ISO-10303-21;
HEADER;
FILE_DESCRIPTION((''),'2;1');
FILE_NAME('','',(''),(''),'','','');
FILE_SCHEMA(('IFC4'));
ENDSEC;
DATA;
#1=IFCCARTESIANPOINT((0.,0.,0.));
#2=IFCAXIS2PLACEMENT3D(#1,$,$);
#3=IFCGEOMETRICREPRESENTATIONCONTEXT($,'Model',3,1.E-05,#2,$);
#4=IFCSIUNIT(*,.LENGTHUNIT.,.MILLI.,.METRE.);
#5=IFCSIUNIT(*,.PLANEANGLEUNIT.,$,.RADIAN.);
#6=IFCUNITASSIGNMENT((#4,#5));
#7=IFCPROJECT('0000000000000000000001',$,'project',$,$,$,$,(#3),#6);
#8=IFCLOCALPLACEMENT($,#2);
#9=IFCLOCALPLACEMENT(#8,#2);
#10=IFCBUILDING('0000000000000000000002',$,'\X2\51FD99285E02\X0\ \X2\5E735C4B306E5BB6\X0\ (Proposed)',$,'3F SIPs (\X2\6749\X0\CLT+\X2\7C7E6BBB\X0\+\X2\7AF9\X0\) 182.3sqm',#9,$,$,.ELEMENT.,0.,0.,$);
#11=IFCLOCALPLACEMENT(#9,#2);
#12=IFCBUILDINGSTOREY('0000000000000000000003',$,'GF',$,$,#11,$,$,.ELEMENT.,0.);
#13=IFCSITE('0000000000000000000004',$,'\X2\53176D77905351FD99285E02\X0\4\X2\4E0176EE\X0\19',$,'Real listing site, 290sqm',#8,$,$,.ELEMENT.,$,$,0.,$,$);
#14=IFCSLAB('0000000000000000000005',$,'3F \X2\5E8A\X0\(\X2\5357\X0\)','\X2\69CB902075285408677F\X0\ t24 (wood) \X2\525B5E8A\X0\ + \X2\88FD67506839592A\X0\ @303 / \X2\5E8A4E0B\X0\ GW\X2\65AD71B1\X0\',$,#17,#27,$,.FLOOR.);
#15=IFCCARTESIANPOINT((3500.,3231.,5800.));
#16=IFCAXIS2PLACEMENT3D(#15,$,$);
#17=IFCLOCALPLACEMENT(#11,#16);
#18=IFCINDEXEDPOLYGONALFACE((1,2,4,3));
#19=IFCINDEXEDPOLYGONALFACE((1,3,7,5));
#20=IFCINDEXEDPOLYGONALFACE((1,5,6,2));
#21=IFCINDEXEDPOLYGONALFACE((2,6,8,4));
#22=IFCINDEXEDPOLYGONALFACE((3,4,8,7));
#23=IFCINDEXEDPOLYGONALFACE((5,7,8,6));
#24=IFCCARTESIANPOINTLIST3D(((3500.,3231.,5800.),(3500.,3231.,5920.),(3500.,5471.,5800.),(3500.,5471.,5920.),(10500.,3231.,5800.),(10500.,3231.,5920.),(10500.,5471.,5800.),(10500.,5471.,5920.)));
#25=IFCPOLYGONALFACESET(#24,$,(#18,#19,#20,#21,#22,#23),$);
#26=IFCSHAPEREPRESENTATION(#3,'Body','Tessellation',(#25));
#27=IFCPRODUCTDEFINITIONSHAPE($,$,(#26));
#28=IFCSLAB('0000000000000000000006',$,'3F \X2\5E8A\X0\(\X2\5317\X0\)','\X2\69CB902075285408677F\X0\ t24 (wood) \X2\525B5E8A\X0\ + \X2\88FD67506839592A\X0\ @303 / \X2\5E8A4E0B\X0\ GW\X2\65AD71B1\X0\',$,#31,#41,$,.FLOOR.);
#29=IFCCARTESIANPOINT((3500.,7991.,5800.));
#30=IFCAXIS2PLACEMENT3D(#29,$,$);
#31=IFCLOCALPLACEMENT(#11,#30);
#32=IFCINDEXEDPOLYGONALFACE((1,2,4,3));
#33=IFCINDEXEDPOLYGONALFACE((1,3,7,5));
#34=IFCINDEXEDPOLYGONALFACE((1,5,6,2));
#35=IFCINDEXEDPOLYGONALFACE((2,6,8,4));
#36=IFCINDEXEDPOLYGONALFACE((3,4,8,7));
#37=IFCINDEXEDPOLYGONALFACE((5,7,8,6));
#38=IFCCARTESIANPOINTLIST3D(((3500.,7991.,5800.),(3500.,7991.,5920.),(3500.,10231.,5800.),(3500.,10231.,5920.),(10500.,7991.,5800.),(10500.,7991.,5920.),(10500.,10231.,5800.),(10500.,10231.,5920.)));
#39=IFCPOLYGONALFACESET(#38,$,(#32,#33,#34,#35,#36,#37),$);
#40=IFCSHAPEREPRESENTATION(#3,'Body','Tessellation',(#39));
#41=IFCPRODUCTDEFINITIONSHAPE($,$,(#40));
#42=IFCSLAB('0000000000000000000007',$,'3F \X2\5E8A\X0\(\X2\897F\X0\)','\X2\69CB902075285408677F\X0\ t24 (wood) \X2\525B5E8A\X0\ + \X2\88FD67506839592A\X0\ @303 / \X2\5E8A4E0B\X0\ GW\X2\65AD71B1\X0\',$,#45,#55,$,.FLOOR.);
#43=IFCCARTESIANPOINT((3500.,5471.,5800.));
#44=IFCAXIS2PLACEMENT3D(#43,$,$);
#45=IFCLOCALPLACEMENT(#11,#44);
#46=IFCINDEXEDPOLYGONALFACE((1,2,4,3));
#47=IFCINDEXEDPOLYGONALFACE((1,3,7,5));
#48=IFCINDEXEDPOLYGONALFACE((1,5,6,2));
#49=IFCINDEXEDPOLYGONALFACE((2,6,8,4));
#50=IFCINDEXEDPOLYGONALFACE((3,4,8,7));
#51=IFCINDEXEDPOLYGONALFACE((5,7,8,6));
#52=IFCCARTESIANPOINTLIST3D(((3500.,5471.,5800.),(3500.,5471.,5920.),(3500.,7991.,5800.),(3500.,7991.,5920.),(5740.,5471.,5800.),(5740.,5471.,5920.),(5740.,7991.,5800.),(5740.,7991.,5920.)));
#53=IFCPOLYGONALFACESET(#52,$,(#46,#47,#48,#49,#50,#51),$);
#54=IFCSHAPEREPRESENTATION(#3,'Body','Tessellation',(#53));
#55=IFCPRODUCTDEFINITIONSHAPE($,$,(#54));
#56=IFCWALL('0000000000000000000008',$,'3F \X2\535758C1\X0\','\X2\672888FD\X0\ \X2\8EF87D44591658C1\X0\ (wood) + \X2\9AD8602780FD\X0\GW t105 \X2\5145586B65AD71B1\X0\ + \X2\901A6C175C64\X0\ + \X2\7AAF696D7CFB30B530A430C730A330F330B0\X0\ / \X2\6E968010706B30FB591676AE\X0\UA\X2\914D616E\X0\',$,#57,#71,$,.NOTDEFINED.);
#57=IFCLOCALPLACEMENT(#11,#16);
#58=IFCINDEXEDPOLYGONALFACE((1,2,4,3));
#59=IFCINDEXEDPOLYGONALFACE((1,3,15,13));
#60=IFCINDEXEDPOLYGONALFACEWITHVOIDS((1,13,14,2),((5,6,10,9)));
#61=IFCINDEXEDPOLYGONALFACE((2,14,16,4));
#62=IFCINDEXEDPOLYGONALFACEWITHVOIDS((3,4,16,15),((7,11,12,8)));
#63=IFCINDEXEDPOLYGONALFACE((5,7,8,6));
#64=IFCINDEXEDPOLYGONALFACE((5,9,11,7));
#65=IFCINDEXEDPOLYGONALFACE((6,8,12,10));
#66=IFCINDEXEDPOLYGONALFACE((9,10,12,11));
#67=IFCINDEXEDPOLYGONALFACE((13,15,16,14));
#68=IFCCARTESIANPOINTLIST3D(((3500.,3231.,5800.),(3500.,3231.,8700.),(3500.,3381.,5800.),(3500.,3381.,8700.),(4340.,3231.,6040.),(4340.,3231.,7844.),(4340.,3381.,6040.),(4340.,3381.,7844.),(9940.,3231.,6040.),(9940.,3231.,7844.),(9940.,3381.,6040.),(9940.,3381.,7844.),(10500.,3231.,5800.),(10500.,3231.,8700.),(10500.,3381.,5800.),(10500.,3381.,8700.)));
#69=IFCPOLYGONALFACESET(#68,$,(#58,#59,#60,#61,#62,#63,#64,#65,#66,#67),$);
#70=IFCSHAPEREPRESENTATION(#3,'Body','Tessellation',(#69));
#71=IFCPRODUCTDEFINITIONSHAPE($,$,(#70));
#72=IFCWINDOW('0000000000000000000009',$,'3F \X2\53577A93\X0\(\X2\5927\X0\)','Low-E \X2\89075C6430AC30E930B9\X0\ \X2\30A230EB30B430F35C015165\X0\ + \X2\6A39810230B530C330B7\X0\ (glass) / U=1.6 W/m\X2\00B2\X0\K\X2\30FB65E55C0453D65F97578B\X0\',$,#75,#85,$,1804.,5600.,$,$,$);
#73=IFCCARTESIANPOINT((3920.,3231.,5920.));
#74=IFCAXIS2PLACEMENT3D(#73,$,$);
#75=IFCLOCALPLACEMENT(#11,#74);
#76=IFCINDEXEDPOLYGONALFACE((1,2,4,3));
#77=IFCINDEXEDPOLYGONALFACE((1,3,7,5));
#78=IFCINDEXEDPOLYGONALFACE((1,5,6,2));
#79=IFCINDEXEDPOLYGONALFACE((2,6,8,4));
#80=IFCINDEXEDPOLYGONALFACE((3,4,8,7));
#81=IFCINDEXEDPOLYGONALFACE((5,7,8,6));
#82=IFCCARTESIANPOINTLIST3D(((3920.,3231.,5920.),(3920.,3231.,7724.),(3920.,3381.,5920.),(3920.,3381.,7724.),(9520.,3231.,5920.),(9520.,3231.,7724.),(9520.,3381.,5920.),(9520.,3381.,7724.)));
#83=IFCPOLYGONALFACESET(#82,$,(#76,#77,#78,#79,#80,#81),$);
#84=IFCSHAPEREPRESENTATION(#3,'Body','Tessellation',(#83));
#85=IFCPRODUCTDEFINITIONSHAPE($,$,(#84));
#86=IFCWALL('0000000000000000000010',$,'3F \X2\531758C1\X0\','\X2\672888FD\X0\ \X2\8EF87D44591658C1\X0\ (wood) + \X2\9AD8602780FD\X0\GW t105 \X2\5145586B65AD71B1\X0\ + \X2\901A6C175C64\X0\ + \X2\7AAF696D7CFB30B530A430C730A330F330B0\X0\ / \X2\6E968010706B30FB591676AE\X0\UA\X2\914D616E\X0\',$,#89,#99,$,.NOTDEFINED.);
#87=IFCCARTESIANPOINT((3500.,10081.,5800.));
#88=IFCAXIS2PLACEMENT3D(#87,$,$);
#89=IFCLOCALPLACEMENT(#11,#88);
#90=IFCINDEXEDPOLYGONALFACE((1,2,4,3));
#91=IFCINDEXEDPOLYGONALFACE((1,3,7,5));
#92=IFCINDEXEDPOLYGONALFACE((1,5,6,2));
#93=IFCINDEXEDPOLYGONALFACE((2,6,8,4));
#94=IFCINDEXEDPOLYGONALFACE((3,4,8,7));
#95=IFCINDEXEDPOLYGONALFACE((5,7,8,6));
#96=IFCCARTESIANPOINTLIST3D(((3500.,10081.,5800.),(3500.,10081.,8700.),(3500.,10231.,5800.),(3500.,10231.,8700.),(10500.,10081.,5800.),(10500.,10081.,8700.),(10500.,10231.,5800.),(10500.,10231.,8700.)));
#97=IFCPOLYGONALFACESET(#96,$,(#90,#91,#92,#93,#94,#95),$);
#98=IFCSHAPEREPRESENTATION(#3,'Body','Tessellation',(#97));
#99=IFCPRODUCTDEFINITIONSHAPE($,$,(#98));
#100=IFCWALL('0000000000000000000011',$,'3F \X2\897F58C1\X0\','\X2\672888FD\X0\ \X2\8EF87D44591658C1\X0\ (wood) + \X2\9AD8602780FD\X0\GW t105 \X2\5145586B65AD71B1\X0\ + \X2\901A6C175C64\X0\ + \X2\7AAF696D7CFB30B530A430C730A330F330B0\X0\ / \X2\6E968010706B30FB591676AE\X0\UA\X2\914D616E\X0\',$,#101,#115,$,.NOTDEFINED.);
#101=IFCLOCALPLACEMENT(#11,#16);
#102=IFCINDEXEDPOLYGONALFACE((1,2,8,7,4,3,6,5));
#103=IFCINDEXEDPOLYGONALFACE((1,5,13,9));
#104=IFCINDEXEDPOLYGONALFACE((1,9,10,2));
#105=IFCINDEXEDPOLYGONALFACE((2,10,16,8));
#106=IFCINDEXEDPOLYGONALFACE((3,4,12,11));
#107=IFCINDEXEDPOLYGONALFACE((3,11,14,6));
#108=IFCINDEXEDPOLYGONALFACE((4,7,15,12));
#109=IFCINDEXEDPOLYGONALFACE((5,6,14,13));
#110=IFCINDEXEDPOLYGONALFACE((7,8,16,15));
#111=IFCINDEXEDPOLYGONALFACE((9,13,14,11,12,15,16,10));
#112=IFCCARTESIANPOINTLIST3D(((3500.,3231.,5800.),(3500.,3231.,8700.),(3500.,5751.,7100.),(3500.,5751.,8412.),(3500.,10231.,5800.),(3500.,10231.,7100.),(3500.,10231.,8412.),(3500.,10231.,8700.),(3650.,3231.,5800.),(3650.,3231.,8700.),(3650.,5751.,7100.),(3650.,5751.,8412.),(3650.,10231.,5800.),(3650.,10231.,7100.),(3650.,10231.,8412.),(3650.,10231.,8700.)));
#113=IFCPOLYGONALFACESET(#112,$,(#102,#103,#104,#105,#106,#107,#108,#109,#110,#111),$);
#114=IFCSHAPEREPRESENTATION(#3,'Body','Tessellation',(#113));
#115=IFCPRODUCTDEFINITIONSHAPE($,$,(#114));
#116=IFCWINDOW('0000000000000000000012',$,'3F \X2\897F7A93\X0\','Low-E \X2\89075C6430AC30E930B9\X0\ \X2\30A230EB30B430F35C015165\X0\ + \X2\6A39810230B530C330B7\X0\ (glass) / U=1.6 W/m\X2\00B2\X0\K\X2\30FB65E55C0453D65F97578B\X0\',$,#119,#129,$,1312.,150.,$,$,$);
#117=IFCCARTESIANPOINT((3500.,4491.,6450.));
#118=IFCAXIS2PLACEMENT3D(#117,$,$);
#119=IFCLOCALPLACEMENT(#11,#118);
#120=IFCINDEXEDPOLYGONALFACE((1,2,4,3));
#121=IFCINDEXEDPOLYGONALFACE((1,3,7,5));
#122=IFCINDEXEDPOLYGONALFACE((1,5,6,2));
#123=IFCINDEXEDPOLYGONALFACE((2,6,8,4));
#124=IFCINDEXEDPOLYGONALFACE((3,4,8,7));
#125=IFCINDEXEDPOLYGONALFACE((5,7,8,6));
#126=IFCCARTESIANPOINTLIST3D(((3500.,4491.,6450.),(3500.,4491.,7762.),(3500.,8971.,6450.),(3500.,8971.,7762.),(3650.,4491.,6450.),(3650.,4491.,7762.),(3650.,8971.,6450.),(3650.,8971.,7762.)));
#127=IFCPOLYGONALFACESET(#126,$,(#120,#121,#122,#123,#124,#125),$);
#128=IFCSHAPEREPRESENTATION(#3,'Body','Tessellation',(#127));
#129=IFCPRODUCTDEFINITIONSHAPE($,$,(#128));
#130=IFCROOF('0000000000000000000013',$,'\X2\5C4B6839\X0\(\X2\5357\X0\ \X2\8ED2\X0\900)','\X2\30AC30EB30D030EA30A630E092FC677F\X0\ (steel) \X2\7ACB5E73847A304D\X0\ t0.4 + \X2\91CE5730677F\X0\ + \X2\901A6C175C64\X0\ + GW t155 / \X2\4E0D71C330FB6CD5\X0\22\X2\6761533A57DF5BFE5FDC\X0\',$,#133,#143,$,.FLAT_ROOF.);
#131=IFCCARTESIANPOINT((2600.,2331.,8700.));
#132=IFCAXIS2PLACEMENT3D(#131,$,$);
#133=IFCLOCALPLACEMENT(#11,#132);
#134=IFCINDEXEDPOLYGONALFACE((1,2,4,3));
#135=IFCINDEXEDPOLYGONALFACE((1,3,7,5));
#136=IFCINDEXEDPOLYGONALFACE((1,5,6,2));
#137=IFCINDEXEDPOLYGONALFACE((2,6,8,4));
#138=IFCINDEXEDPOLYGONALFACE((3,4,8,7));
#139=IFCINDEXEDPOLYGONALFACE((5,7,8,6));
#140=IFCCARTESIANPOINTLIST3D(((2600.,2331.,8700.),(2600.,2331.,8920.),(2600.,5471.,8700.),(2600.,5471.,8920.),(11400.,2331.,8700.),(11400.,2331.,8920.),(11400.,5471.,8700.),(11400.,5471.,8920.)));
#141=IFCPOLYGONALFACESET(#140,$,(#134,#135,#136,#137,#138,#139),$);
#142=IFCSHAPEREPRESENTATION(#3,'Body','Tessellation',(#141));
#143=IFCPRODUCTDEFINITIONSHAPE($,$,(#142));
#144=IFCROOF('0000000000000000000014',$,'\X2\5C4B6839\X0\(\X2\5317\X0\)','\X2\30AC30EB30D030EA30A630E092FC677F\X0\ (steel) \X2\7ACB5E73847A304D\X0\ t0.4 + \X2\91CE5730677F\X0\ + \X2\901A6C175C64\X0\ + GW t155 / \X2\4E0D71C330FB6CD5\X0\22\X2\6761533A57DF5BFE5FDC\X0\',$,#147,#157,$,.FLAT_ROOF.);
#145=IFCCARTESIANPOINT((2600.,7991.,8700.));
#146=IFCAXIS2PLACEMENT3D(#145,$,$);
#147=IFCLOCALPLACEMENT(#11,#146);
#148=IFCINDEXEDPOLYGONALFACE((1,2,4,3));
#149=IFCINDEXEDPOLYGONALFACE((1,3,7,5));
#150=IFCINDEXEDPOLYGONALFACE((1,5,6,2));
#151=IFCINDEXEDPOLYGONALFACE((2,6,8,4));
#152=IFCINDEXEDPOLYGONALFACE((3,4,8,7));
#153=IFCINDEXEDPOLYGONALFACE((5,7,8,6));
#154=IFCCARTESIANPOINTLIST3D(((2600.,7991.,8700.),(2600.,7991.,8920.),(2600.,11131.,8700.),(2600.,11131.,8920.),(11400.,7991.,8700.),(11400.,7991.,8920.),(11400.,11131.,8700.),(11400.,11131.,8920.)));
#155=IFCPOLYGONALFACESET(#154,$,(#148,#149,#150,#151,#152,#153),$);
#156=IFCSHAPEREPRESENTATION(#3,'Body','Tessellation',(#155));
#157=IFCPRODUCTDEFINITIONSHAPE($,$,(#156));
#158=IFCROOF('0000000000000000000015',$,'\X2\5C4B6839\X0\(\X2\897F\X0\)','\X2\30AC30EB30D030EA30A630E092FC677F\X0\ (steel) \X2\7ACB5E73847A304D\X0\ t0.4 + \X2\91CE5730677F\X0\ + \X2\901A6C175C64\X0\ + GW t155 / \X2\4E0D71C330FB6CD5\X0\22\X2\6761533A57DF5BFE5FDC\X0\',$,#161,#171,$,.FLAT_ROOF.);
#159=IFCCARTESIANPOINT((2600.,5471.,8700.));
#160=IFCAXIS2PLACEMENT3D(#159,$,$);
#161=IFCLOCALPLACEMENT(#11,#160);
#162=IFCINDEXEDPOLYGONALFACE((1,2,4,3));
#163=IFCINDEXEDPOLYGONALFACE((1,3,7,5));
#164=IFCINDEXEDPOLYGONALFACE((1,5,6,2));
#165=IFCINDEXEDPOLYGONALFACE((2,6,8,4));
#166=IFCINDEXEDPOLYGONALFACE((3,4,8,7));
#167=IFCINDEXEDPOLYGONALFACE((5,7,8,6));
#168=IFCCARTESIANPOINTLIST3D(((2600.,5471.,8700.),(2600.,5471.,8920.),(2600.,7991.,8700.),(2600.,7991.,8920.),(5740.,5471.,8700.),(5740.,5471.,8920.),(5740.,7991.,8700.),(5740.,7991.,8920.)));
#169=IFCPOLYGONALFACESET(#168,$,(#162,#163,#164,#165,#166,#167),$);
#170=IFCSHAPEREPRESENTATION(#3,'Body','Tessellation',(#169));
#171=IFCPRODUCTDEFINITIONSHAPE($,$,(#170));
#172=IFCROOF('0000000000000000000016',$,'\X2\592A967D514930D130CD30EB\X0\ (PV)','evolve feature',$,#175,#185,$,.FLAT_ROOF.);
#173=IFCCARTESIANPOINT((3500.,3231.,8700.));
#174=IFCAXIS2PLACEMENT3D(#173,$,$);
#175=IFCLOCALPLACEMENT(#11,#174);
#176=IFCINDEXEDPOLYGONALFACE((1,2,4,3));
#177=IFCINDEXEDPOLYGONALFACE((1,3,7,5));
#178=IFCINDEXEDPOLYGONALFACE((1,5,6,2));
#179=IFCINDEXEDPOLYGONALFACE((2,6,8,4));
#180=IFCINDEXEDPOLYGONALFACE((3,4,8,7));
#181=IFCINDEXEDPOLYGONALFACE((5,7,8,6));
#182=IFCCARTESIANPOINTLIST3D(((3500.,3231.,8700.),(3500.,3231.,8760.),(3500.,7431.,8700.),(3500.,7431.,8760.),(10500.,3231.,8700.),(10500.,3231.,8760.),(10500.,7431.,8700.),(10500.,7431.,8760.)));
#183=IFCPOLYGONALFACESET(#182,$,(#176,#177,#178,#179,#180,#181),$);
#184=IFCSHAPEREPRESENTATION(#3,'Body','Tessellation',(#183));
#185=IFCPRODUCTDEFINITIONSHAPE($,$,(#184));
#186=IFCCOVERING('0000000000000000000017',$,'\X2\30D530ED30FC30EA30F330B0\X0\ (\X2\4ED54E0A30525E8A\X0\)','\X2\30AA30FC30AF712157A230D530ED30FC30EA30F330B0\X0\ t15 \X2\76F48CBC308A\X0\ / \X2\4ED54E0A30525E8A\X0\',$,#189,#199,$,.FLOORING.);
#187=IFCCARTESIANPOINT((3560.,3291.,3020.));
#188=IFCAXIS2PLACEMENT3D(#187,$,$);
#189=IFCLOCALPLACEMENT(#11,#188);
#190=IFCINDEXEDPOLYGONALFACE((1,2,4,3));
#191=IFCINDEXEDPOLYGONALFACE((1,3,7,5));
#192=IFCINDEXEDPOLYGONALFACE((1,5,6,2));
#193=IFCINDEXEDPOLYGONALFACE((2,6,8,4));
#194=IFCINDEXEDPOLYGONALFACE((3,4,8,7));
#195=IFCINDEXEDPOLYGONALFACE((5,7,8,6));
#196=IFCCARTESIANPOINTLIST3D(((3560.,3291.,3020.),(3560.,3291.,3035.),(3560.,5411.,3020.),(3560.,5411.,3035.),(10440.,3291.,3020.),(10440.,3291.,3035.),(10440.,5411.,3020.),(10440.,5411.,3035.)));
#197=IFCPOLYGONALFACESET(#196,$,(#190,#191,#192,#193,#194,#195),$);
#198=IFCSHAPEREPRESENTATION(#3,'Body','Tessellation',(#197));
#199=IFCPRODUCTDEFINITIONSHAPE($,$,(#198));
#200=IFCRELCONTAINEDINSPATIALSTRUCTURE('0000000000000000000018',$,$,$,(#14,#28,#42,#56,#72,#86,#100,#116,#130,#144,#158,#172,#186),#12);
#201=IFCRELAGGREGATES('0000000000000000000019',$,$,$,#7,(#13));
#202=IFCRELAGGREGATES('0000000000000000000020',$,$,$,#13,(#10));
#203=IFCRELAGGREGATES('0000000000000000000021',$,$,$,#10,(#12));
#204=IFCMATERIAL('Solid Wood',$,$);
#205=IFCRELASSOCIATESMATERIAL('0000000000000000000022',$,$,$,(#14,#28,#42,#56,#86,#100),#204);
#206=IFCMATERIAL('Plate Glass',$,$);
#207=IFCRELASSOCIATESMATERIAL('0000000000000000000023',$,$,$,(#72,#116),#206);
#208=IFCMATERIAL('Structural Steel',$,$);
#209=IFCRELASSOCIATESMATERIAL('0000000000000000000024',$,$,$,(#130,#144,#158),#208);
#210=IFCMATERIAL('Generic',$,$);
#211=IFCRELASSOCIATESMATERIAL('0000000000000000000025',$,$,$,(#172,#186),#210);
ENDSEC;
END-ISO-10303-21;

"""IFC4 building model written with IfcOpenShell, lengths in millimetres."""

from ifc_helpers import new_model, si_unit, frame, frame_2d, origin, place, context, project, spatial, rectangle, extrude, material, element, fill, save


model = new_model("IFC4")

# Units and contexts
model_context = context("Model", 3, precision=1e-05, world=origin())
ifc_project = project(units=[si_unit("LENGTHUNIT", "METRE", prefix="MILLI"), si_unit("PLANEANGLEUNIT", "RADIAN")], contexts=[model_context])

# Site, building, storey
site_placement = place(None, origin())
site = spatial("IfcSite", under=ifc_project, at=site_placement, Name="北海道函館市4丁目19", ObjectType="Real listing site, 290sqm", CompositionType="ELEMENT", RefElevation=0.0)
building_placement = place(site_placement, origin())
building = spatial("IfcBuilding", under=site, at=building_placement, Name="函館市 平屋の家 (Proposed)", ObjectType="3F SIPs (杉CLT+籾殻+竹) 182.3sqm", CompositionType="ELEMENT", ElevationOfRefHeight=0.0, ElevationOfTerrain=0.0)
storey_placement = place(building_placement, origin())
storey = spatial("IfcBuildingStorey", under=building, at=storey_placement, Name="GF", CompositionType="ELEMENT", Elevation=0.0)

# Slabs
ifc_material_1 = material(Name="Solid Wood")
slab_1_placement = place(storey_placement, frame((3500.0, 3231.0, 5800.0)))
element("IfcSlab", 1, at=slab_1_placement, inside=storey, material=ifc_material_1, Name="3F 床(南)", Description="構造用合板 t24 (wood) 剛床 + 製材根太 @303 / 床下 GW断熱", PredefinedType="FLOOR", context=model_context, shape_type="SweptSolid", body=[
    extrude(rectangle(XDim=7000.0, YDim=2240.0, at=frame_2d((3500.0, 1120.0))), frame((3500.0, 3231.0, 5800.0)), (0.0, 0.0, 1.0), 120.0),
])
slab_2_placement = place(storey_placement, frame((3500.0, 7991.0, 5800.0)))
element("IfcSlab", 2, at=slab_2_placement, inside=storey, material=ifc_material_1, Name="3F 床(北)", Description="構造用合板 t24 (wood) 剛床 + 製材根太 @303 / 床下 GW断熱", PredefinedType="FLOOR", context=model_context, shape_type="SweptSolid", body=[
    extrude(rectangle(XDim=7000.0, YDim=2240.0, at=frame_2d((3500.0, 1120.0))), frame((3500.0, 7991.0, 5800.0)), (0.0, 0.0, 1.0), 120.0),
])
slab_3_placement = place(storey_placement, frame((3500.0, 5471.0, 5800.0)))
element("IfcSlab", 3, at=slab_3_placement, inside=storey, material=ifc_material_1, Name="3F 床(西)", Description="構造用合板 t24 (wood) 剛床 + 製材根太 @303 / 床下 GW断熱", PredefinedType="FLOOR", context=model_context, shape_type="SweptSolid", body=[
    extrude(rectangle(XDim=2240.0, YDim=2520.0, at=frame_2d((1120.0, 1260.0))), frame((3500.0, 5471.0, 5800.0)), (0.0, 0.0, 1.0), 120.0),
])

# Wall, opening, window
wall_1_placement = place(storey_placement, frame((3500.0, 3231.0, 5800.0)))
wall_1 = element("IfcWall", 4, at=wall_1_placement, inside=storey, material=ifc_material_1, Name="3F 南壁", Description="木製 軸組外壁 (wood) + 高性能GW t105 充填断熱 + 通気層 + 窯業系サイディング / 準耐火・外皮UA配慮", PredefinedType="NOTDEFINED", context=model_context, shape_type="SweptSolid", body=[
    extrude(rectangle(XDim=7000.0, YDim=150.0, at=frame_2d((3500.0, 75.0))), frame((3500.0, 3231.0, 5800.0)), (0.0, 0.0, 1.0), 2900.0),
])
opening_1_placement = place(storey_placement, frame((3920.0, 3231.0, 5920.0)))
opening_1 = element("IfcOpeningElement", 5, at=opening_1_placement, cuts=wall_1, PredefinedType="NOTDEFINED", context=model_context, shape_type="SweptSolid", body=[
    extrude(rectangle(XDim=5600.0, YDim=150.0, at=frame_2d((2800.0, 75.0))), frame((3920.0, 3231.0, 5920.0)), (0.0, 0.0, 1.0), 1804.0),
])
ifc_material_2 = material(Name="Plate Glass")
window_1_placement = place(storey_placement, frame((3920.0, 3231.0, 5920.0)))
window_1 = element("IfcWindow", 6, at=window_1_placement, inside=storey, material=ifc_material_2, Name="3F 南窓(大)", Description="Low-E 複層ガラス アルゴン封入 + 樹脂サッシ (glass) / U=1.6 W/m²K・日射取得型", OverallHeight=1804.0, OverallWidth=5600.0, context=model_context, shape_type="SweptSolid", body=[
    extrude(rectangle(XDim=5600.0, YDim=150.0, at=frame_2d((2800.0, 75.0))), frame((3920.0, 3231.0, 5920.0)), (0.0, 0.0, 1.0), 1804.0),
])
fill(opening_1, window_1)

# Wall
wall_2_placement = place(storey_placement, frame((3500.0, 10081.0, 5800.0)))
element("IfcWall", 7, at=wall_2_placement, inside=storey, material=ifc_material_1, Name="3F 北壁", Description="木製 軸組外壁 (wood) + 高性能GW t105 充填断熱 + 通気層 + 窯業系サイディング / 準耐火・外皮UA配慮", PredefinedType="NOTDEFINED", context=model_context, shape_type="SweptSolid", body=[
    extrude(rectangle(XDim=7000.0, YDim=150.0, at=frame_2d((3500.0, 75.0))), frame((3500.0, 10081.0, 5800.0)), (0.0, 0.0, 1.0), 2900.0),
])

# Wall, opening, window
wall_3_placement = place(storey_placement, frame((3500.0, 3231.0, 5800.0)))
wall_3 = element("IfcWall", 8, at=wall_3_placement, inside=storey, material=ifc_material_1, Name="3F 西壁", Description="木製 軸組外壁 (wood) + 高性能GW t105 充填断熱 + 通気層 + 窯業系サイディング / 準耐火・外皮UA配慮", PredefinedType="NOTDEFINED", context=model_context, shape_type="SweptSolid", body=[
    extrude(rectangle(XDim=150.0, YDim=7000.0, at=frame_2d((75.0, 3500.0))), frame((3500.0, 3231.0, 5800.0)), (0.0, 0.0, 1.0), 2900.0),
])
opening_2_placement = place(storey_placement, frame((3500.0, 4491.0, 6450.0)))
opening_2 = element("IfcOpeningElement", 9, at=opening_2_placement, cuts=wall_3, PredefinedType="NOTDEFINED", context=model_context, shape_type="SweptSolid", body=[
    extrude(rectangle(XDim=150.0, YDim=4480.0, at=frame_2d((75.0, 2240.0))), frame((3500.0, 4491.0, 6450.0)), (0.0, 0.0, 1.0), 1312.0),
])
window_2_placement = place(storey_placement, frame((3500.0, 4491.0, 6450.0)))
window_2 = element("IfcWindow", 10, at=window_2_placement, inside=storey, material=ifc_material_2, Name="3F 西窓", Description="Low-E 複層ガラス アルゴン封入 + 樹脂サッシ (glass) / U=1.6 W/m²K・日射取得型", OverallHeight=1312.0, OverallWidth=150.0, context=model_context, shape_type="SweptSolid", body=[
    extrude(rectangle(XDim=150.0, YDim=4480.0, at=frame_2d((75.0, 2240.0))), frame((3500.0, 4491.0, 6450.0)), (0.0, 0.0, 1.0), 1312.0),
])
fill(opening_2, window_2)

# Roofs
ifc_material_3 = material(Name="Structural Steel")
roof_1_placement = place(storey_placement, frame((2600.0, 2331.0, 8700.0)))
element("IfcRoof", 11, at=roof_1_placement, inside=storey, material=ifc_material_3, Name="屋根(南 軒900)", Description="ガルバリウム鋼板 (steel) 立平葺き t0.4 + 野地板 + 通気層 + GW t155 / 不燃・法22条区域対応", PredefinedType="FLAT_ROOF", context=model_context, shape_type="SweptSolid", body=[
    extrude(rectangle(XDim=8800.0, YDim=3140.0, at=frame_2d((4400.0, 1570.0))), frame((2600.0, 2331.0, 8700.0)), (0.0, 0.0, 1.0), 220.0),
])
roof_2_placement = place(storey_placement, frame((2600.0, 7991.0, 8700.0)))
element("IfcRoof", 12, at=roof_2_placement, inside=storey, material=ifc_material_3, Name="屋根(北)", Description="ガルバリウム鋼板 (steel) 立平葺き t0.4 + 野地板 + 通気層 + GW t155 / 不燃・法22条区域対応", PredefinedType="FLAT_ROOF", context=model_context, shape_type="SweptSolid", body=[
    extrude(rectangle(XDim=8800.0, YDim=3140.0, at=frame_2d((4400.0, 1570.0))), frame((2600.0, 7991.0, 8700.0)), (0.0, 0.0, 1.0), 220.0),
])
roof_3_placement = place(storey_placement, frame((2600.0, 5471.0, 8700.0)))
element("IfcRoof", 13, at=roof_3_placement, inside=storey, material=ifc_material_3, Name="屋根(西)", Description="ガルバリウム鋼板 (steel) 立平葺き t0.4 + 野地板 + 通気層 + GW t155 / 不燃・法22条区域対応", PredefinedType="FLAT_ROOF", context=model_context, shape_type="SweptSolid", body=[
    extrude(rectangle(XDim=3140.0, YDim=2520.0, at=frame_2d((1570.0, 1260.0))), frame((2600.0, 5471.0, 8700.0)), (0.0, 0.0, 1.0), 220.0),
])
ifc_material_4 = material(Name="Generic")
roof_4_placement = place(storey_placement, frame((3500.0, 3231.0, 8700.0)))
element("IfcRoof", 14, at=roof_4_placement, inside=storey, material=ifc_material_4, Name="太陽光パネル (PV)", Description="evolve feature", PredefinedType="FLAT_ROOF", context=model_context, shape_type="SweptSolid", body=[
    extrude(rectangle(XDim=7000.0, YDim=4200.0, at=frame_2d((3500.0, 2100.0))), frame((3500.0, 3231.0, 8700.0)), (0.0, 0.0, 1.0), 60.0),
])

# Covering
covering_1_placement = place(storey_placement, frame((3560.0, 3291.0, 3020.0)))
element("IfcCovering", 15, at=covering_1_placement, inside=storey, material=ifc_material_4, Name="フローリング (仕上げ床)", Description="オーク無垢フローリング t15 直貼り / 仕上げ床", PredefinedType="FLOORING", context=model_context, shape_type="SweptSolid", body=[
    extrude(rectangle(XDim=6880.0, YDim=2120.0, at=frame_2d((3440.0, 1060.0))), frame((3560.0, 3291.0, 3020.0)), (0.0, 0.0, 1.0), 15.0),
])

save(model, "model.ifc")
